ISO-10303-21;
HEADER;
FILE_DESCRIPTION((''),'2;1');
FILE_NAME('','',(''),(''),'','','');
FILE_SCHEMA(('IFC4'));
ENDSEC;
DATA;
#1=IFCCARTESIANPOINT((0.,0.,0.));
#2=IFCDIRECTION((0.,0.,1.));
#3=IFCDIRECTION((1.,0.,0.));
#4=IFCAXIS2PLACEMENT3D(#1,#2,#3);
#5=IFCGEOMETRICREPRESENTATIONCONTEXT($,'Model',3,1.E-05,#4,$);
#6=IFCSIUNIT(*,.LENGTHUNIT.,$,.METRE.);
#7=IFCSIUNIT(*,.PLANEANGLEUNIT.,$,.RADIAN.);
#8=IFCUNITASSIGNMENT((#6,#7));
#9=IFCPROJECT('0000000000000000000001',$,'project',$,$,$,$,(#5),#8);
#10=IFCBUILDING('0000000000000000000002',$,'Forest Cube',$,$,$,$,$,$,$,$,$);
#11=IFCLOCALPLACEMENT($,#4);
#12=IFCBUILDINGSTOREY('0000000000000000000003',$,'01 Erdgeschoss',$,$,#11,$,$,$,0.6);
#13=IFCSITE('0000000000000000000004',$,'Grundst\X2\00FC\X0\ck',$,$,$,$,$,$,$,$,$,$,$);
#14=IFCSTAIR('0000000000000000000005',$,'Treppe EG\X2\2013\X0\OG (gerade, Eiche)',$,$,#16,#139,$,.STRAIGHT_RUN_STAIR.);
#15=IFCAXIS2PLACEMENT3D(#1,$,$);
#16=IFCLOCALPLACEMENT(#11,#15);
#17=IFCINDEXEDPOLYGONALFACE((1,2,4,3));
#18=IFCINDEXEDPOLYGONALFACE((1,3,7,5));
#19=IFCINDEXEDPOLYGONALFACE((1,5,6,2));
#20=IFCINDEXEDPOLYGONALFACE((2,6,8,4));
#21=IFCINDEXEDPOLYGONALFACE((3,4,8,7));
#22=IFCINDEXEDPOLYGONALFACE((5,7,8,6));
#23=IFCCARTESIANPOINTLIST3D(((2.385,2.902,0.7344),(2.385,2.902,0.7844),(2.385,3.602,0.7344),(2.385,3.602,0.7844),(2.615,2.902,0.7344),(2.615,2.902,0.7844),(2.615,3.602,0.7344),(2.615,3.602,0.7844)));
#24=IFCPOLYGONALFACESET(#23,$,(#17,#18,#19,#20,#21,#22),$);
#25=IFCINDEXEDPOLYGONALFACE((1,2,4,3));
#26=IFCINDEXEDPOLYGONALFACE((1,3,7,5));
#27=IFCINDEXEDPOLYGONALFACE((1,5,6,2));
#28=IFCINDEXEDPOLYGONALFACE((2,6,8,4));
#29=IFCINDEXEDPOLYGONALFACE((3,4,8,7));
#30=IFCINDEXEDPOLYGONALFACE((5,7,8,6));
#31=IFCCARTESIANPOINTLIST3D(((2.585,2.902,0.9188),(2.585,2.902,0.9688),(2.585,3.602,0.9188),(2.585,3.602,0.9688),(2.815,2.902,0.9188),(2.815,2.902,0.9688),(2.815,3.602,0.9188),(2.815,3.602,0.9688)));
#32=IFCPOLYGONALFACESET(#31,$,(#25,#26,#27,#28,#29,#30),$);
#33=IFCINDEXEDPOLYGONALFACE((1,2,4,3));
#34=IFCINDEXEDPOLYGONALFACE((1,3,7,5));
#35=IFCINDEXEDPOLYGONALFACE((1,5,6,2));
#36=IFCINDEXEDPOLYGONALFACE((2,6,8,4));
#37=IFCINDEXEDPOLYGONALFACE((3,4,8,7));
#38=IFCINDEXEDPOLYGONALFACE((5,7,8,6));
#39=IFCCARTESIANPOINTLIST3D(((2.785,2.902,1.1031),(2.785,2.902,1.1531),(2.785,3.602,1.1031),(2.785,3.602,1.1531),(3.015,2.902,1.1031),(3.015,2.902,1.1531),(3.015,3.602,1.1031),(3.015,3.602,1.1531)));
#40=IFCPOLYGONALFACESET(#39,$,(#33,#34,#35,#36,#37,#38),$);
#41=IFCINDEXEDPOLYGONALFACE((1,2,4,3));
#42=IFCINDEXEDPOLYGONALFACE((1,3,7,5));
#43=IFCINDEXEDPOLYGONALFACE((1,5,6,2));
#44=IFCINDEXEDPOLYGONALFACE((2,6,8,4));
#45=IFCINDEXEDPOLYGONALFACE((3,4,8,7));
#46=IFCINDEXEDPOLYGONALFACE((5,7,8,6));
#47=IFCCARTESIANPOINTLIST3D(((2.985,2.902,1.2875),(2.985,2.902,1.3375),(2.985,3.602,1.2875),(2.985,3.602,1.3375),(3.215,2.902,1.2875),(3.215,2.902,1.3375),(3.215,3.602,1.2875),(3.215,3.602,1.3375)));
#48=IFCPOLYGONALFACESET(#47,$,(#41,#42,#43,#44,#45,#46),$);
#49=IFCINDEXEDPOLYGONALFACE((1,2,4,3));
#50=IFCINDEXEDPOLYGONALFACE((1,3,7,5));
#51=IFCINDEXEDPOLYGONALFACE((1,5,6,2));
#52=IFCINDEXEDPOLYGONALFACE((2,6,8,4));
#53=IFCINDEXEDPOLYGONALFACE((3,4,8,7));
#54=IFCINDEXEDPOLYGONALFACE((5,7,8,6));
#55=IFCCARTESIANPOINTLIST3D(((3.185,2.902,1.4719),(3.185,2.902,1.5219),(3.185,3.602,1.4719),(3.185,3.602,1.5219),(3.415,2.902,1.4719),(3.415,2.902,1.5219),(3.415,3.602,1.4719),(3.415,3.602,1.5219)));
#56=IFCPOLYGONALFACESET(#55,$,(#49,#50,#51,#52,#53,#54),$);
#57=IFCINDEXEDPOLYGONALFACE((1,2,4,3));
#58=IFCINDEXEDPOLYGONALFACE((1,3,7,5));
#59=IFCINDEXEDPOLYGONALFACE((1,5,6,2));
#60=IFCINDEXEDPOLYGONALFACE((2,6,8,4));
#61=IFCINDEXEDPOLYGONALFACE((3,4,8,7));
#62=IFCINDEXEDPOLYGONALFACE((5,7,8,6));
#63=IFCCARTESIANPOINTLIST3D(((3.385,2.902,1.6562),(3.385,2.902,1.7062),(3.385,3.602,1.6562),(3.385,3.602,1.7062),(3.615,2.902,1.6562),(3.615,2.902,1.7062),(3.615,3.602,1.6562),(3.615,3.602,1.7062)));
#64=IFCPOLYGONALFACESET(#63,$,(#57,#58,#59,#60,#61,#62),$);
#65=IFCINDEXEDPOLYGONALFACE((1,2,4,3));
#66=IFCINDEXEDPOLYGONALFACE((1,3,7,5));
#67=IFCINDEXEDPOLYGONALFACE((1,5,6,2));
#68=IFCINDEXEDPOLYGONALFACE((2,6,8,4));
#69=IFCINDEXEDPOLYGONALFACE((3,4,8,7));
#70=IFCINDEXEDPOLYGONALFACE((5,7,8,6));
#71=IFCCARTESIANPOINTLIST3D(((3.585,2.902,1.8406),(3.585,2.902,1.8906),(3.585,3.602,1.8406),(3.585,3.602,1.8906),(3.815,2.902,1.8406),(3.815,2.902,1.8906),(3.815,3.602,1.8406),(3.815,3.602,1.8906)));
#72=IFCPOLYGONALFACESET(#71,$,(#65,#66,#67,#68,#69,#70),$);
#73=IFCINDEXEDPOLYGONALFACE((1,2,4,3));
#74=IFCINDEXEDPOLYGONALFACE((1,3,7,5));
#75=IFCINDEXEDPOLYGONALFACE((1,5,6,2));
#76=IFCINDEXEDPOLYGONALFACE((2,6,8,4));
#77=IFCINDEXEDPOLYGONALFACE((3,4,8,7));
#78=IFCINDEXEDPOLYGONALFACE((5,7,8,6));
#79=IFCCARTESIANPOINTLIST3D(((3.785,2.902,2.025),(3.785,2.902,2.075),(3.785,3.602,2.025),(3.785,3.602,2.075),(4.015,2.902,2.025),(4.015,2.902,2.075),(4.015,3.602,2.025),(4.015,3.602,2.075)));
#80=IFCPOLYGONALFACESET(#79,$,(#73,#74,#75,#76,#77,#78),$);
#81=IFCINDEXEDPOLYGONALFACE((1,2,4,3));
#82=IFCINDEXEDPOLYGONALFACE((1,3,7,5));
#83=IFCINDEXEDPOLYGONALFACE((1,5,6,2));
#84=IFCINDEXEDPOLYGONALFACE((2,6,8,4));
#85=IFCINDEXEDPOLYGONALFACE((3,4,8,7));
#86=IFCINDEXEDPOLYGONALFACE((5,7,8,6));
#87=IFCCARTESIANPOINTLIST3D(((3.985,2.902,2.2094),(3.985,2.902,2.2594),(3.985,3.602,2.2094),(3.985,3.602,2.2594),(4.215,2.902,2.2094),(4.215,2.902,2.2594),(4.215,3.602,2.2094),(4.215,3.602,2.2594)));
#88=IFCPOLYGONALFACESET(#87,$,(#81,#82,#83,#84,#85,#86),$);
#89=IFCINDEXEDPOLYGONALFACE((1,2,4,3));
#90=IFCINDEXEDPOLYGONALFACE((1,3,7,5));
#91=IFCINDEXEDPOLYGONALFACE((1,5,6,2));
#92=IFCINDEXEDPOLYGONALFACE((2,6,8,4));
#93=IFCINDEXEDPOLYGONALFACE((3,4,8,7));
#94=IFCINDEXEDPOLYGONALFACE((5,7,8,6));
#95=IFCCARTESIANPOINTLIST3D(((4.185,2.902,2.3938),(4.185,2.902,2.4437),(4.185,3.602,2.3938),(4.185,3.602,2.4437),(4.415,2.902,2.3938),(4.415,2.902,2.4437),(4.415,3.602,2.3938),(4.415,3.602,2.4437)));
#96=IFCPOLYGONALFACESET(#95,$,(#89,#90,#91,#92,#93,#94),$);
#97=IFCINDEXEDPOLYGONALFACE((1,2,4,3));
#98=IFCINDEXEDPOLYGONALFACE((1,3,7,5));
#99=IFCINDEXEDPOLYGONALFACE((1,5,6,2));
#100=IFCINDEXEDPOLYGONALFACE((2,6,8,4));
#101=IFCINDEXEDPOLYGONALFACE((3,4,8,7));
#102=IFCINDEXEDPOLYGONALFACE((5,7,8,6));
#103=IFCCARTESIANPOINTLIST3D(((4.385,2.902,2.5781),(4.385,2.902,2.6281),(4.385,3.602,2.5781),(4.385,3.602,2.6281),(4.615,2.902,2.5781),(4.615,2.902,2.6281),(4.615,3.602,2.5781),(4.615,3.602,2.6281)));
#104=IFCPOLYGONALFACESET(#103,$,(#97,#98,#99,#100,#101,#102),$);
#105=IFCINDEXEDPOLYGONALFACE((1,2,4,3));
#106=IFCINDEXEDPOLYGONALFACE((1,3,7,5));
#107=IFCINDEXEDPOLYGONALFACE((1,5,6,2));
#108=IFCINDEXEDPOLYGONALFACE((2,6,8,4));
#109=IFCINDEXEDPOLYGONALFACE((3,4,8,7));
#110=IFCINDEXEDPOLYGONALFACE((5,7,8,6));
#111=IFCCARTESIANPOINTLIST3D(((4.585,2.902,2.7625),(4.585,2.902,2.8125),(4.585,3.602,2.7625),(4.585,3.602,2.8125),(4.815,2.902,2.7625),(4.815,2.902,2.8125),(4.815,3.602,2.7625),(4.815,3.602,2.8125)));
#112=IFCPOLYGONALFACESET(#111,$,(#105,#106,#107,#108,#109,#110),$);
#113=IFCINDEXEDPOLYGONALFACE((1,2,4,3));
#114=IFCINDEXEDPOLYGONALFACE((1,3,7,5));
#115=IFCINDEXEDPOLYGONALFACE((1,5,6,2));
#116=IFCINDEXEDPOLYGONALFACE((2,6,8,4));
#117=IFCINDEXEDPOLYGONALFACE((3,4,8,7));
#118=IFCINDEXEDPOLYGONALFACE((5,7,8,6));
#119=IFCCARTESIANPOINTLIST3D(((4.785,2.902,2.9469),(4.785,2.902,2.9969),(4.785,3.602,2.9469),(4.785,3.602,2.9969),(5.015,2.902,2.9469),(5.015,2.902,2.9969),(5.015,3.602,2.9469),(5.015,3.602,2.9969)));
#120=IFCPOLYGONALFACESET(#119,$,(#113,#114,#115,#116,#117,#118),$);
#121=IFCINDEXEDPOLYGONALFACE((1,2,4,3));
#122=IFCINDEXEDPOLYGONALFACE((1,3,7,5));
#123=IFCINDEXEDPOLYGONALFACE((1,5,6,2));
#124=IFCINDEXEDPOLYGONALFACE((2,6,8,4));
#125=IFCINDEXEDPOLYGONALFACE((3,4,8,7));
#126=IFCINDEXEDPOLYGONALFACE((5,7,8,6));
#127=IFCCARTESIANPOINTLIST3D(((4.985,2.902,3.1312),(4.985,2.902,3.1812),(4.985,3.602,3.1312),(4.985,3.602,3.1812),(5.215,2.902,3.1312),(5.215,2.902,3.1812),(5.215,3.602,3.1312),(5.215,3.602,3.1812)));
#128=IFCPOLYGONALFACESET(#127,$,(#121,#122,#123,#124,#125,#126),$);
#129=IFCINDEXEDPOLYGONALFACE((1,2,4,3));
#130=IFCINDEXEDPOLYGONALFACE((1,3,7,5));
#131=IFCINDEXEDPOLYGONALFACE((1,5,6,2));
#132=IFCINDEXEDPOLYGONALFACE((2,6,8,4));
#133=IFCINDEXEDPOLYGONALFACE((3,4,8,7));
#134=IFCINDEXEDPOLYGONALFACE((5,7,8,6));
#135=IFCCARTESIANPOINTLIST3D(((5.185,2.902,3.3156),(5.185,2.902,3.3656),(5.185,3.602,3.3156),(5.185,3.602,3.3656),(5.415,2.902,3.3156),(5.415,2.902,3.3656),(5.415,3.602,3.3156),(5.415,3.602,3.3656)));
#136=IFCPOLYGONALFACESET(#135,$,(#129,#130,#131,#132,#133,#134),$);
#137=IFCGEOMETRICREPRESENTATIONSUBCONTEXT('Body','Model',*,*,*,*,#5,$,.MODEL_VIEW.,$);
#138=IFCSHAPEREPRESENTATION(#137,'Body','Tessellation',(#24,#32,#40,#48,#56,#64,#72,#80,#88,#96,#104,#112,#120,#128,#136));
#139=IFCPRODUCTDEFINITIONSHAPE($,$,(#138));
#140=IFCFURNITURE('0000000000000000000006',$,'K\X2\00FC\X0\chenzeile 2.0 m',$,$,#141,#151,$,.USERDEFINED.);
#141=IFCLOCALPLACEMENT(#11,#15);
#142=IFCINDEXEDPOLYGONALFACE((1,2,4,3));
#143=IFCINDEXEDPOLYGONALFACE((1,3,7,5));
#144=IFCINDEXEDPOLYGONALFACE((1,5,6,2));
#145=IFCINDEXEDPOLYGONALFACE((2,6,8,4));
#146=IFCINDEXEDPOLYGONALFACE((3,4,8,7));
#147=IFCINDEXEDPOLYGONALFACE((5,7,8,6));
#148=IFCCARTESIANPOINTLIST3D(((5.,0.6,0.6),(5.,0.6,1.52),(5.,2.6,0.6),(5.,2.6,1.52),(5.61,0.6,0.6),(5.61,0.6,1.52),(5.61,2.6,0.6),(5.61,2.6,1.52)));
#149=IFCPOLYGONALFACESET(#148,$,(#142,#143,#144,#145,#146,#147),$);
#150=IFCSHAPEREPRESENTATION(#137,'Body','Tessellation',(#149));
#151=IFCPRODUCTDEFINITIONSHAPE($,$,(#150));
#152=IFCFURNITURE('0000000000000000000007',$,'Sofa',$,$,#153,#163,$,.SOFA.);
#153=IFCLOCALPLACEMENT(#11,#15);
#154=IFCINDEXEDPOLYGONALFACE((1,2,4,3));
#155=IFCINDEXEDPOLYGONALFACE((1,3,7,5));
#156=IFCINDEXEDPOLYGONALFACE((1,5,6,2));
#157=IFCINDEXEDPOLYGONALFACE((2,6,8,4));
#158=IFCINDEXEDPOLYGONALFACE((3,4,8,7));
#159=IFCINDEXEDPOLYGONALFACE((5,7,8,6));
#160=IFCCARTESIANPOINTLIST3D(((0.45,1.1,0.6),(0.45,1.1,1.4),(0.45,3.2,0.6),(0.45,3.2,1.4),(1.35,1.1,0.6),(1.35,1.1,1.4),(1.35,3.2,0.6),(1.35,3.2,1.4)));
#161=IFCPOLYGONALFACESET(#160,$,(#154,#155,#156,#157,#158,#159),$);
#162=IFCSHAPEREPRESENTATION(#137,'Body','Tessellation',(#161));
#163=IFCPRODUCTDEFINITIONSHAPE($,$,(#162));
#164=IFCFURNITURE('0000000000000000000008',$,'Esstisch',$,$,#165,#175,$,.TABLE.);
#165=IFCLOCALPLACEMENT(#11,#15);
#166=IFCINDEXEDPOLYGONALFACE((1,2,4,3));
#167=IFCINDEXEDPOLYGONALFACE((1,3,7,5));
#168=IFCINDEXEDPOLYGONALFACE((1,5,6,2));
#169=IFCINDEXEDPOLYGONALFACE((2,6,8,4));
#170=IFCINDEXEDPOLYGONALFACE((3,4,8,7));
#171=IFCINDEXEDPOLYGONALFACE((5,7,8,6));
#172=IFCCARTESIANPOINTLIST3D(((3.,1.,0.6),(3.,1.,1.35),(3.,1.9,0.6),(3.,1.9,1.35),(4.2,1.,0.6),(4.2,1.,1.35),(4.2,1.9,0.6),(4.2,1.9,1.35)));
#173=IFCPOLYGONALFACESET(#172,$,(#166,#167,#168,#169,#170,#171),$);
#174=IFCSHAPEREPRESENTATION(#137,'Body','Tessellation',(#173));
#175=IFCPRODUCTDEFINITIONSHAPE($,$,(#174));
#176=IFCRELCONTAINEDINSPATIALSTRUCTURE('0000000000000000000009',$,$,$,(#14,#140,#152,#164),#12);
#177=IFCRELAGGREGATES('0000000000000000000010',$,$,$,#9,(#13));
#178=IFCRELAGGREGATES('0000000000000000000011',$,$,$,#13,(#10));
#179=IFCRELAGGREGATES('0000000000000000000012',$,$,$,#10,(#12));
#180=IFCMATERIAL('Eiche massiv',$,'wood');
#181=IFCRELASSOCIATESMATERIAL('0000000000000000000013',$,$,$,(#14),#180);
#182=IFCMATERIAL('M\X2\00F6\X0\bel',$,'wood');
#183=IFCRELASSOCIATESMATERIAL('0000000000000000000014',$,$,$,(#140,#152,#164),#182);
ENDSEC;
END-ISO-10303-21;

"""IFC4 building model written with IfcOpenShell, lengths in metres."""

from ifc_helpers import new_model, si_unit, frame, frame_2d, origin_with_axes, place, context, subcontext, project, spatial, indexed_curve, rectangle, outline, extrude, material, element, save


model = new_model("IFC4")

# Units and contexts
model_context = context("Model", 3, precision=1e-05, world=origin_with_axes())
body_context = subcontext(model_context, "Body", "Model", "MODEL_VIEW")
ifc_project = project(units=[si_unit("LENGTHUNIT", "METRE"), si_unit("PLANEANGLEUNIT", "RADIAN")], contexts=[model_context])

# Site, building, storey
site = spatial("IfcSite", under=ifc_project, Name="Grundstück")
building = spatial("IfcBuilding", under=site, Name="Forest Cube")
storey_placement = place(None, origin_with_axes())
storey = spatial("IfcBuildingStorey", under=building, at=storey_placement, Name="01 Erdgeschoss", Elevation=0.6)

# Stair
ifc_material_1 = material(Name="Eiche massiv", Category="wood")
stair_placement = place(storey_placement, origin_with_axes())
element("IfcStair", 1, at=stair_placement, inside=storey, material=ifc_material_1, Name="Treppe EG–OG (gerade, Eiche)", PredefinedType="STRAIGHT_RUN_STAIR", context=body_context, shape_type="SweptSolid", body=[
    extrude(rectangle(XDim=0.23, YDim=0.7, at=frame_2d((2.5, 3.252))), frame((0.0, 0.0, 0.7344)), (0.0, 0.0, 1.0), 0.05),
    extrude(rectangle(XDim=0.23, YDim=0.7, at=frame_2d((2.7, 3.252))), frame((0.0, 0.0, 0.9187)), (0.0, 0.0, 1.0), 0.05),
    extrude(rectangle(XDim=0.23, YDim=0.7, at=frame_2d((2.9, 3.252))), frame((0.0, 0.0, 1.1031)), (0.0, 0.0, 1.0), 0.05),
    extrude(rectangle(XDim=0.23, YDim=0.7, at=frame_2d((3.1, 3.252))), frame((0.0, 0.0, 1.2875)), (0.0, 0.0, 1.0), 0.05),
    extrude(rectangle(XDim=0.23, YDim=0.7, at=frame_2d((3.3, 3.252))), frame((0.0, 0.0, 1.4719)), (0.0, 0.0, 1.0), 0.05),
    extrude(rectangle(XDim=0.23, YDim=0.7, at=frame_2d((3.5, 3.252))), frame((0.0, 0.0, 1.6562)), (0.0, 0.0, 1.0), 0.05),
    extrude(rectangle(XDim=0.23, YDim=0.7, at=frame_2d((3.7, 3.252))), frame((0.0, 0.0, 1.8406)), (0.0, 0.0, 1.0), 0.05),
    extrude(rectangle(XDim=0.23, YDim=0.7, at=frame_2d((3.9, 3.252))), frame((0.0, 0.0, 2.025)), (0.0, 0.0, 1.0), 0.05),
    extrude(rectangle(XDim=0.23, YDim=0.7, at=frame_2d((4.1, 3.252))), frame((0.0, 0.0, 2.2094)), (0.0, 0.0, 1.0), 0.05),
    extrude(rectangle(XDim=0.23, YDim=0.7, at=frame_2d((4.3, 3.252))), frame((0.0, 0.0, 2.3937)), (0.0, 0.0, 1.0), 0.05),
    extrude(rectangle(XDim=0.23, YDim=0.7, at=frame_2d((4.5, 3.252))), frame((0.0, 0.0, 2.5781)), (0.0, 0.0, 1.0), 0.05),
    extrude(rectangle(XDim=0.23, YDim=0.7, at=frame_2d((4.7, 3.252))), frame((0.0, 0.0, 2.7625)), (0.0, 0.0, 1.0), 0.05),
    extrude(rectangle(XDim=0.23, YDim=0.7, at=frame_2d((4.9, 3.252))), frame((0.0, 0.0, 2.9469)), (0.0, 0.0, 1.0), 0.05),
    extrude(rectangle(XDim=0.23, YDim=0.7, at=frame_2d((5.1, 3.252))), frame((0.0, 0.0, 3.1313)), (0.0, 0.0, 1.0), 0.05),
    extrude(rectangle(XDim=0.23, YDim=0.7, at=frame_2d((5.3, 3.252))), frame((0.0, 0.0, 3.3156)), (0.0, 0.0, 1.0), 0.05),
])

# Furniture
ifc_material_2 = material(Name="Möbel", Category="wood")
furniture_1_placement = place(storey_placement, frame((0.0, 0.0, 0.6), z_axis=(0.0, 0.0, 1.0), x_axis=(1.0, 0.0, 0.0)))
element("IfcFurniture", 2, at=furniture_1_placement, inside=storey, material=ifc_material_2, Name="Küchenzeile 2.0 m", PredefinedType="USERDEFINED", context=body_context, shape_type="SweptSolid", body=[
    extrude(outline(indexed_curve([(5.0, 0.6), (5.61, 0.6), (5.61, 2.6), (5.0, 2.6)])), None, (0.0, 0.0, 1.0), 0.92),
])
furniture_2_placement = place(storey_placement, frame((0.0, 0.0, 0.6), z_axis=(0.0, 0.0, 1.0), x_axis=(1.0, 0.0, 0.0)))
element("IfcFurniture", 3, at=furniture_2_placement, inside=storey, material=ifc_material_2, Name="Sofa", PredefinedType="SOFA", context=body_context, shape_type="SweptSolid", body=[
    extrude(outline(indexed_curve([(0.45, 1.1), (1.35, 1.1), (1.35, 3.2), (0.45, 3.2)])), None, (0.0, 0.0, 1.0), 0.8),
])
furniture_3_placement = place(storey_placement, frame((0.0, 0.0, 0.6), z_axis=(0.0, 0.0, 1.0), x_axis=(1.0, 0.0, 0.0)))
element("IfcFurniture", 4, at=furniture_3_placement, inside=storey, material=ifc_material_2, Name="Esstisch", PredefinedType="TABLE", context=body_context, shape_type="SweptSolid", body=[
    extrude(outline(indexed_curve([(3.0, 1.0), (4.2, 1.0), (4.2, 1.9), (3.0, 1.9)])), None, (0.0, 0.0, 1.0), 0.75),
])

save(model, "model.ifc")
